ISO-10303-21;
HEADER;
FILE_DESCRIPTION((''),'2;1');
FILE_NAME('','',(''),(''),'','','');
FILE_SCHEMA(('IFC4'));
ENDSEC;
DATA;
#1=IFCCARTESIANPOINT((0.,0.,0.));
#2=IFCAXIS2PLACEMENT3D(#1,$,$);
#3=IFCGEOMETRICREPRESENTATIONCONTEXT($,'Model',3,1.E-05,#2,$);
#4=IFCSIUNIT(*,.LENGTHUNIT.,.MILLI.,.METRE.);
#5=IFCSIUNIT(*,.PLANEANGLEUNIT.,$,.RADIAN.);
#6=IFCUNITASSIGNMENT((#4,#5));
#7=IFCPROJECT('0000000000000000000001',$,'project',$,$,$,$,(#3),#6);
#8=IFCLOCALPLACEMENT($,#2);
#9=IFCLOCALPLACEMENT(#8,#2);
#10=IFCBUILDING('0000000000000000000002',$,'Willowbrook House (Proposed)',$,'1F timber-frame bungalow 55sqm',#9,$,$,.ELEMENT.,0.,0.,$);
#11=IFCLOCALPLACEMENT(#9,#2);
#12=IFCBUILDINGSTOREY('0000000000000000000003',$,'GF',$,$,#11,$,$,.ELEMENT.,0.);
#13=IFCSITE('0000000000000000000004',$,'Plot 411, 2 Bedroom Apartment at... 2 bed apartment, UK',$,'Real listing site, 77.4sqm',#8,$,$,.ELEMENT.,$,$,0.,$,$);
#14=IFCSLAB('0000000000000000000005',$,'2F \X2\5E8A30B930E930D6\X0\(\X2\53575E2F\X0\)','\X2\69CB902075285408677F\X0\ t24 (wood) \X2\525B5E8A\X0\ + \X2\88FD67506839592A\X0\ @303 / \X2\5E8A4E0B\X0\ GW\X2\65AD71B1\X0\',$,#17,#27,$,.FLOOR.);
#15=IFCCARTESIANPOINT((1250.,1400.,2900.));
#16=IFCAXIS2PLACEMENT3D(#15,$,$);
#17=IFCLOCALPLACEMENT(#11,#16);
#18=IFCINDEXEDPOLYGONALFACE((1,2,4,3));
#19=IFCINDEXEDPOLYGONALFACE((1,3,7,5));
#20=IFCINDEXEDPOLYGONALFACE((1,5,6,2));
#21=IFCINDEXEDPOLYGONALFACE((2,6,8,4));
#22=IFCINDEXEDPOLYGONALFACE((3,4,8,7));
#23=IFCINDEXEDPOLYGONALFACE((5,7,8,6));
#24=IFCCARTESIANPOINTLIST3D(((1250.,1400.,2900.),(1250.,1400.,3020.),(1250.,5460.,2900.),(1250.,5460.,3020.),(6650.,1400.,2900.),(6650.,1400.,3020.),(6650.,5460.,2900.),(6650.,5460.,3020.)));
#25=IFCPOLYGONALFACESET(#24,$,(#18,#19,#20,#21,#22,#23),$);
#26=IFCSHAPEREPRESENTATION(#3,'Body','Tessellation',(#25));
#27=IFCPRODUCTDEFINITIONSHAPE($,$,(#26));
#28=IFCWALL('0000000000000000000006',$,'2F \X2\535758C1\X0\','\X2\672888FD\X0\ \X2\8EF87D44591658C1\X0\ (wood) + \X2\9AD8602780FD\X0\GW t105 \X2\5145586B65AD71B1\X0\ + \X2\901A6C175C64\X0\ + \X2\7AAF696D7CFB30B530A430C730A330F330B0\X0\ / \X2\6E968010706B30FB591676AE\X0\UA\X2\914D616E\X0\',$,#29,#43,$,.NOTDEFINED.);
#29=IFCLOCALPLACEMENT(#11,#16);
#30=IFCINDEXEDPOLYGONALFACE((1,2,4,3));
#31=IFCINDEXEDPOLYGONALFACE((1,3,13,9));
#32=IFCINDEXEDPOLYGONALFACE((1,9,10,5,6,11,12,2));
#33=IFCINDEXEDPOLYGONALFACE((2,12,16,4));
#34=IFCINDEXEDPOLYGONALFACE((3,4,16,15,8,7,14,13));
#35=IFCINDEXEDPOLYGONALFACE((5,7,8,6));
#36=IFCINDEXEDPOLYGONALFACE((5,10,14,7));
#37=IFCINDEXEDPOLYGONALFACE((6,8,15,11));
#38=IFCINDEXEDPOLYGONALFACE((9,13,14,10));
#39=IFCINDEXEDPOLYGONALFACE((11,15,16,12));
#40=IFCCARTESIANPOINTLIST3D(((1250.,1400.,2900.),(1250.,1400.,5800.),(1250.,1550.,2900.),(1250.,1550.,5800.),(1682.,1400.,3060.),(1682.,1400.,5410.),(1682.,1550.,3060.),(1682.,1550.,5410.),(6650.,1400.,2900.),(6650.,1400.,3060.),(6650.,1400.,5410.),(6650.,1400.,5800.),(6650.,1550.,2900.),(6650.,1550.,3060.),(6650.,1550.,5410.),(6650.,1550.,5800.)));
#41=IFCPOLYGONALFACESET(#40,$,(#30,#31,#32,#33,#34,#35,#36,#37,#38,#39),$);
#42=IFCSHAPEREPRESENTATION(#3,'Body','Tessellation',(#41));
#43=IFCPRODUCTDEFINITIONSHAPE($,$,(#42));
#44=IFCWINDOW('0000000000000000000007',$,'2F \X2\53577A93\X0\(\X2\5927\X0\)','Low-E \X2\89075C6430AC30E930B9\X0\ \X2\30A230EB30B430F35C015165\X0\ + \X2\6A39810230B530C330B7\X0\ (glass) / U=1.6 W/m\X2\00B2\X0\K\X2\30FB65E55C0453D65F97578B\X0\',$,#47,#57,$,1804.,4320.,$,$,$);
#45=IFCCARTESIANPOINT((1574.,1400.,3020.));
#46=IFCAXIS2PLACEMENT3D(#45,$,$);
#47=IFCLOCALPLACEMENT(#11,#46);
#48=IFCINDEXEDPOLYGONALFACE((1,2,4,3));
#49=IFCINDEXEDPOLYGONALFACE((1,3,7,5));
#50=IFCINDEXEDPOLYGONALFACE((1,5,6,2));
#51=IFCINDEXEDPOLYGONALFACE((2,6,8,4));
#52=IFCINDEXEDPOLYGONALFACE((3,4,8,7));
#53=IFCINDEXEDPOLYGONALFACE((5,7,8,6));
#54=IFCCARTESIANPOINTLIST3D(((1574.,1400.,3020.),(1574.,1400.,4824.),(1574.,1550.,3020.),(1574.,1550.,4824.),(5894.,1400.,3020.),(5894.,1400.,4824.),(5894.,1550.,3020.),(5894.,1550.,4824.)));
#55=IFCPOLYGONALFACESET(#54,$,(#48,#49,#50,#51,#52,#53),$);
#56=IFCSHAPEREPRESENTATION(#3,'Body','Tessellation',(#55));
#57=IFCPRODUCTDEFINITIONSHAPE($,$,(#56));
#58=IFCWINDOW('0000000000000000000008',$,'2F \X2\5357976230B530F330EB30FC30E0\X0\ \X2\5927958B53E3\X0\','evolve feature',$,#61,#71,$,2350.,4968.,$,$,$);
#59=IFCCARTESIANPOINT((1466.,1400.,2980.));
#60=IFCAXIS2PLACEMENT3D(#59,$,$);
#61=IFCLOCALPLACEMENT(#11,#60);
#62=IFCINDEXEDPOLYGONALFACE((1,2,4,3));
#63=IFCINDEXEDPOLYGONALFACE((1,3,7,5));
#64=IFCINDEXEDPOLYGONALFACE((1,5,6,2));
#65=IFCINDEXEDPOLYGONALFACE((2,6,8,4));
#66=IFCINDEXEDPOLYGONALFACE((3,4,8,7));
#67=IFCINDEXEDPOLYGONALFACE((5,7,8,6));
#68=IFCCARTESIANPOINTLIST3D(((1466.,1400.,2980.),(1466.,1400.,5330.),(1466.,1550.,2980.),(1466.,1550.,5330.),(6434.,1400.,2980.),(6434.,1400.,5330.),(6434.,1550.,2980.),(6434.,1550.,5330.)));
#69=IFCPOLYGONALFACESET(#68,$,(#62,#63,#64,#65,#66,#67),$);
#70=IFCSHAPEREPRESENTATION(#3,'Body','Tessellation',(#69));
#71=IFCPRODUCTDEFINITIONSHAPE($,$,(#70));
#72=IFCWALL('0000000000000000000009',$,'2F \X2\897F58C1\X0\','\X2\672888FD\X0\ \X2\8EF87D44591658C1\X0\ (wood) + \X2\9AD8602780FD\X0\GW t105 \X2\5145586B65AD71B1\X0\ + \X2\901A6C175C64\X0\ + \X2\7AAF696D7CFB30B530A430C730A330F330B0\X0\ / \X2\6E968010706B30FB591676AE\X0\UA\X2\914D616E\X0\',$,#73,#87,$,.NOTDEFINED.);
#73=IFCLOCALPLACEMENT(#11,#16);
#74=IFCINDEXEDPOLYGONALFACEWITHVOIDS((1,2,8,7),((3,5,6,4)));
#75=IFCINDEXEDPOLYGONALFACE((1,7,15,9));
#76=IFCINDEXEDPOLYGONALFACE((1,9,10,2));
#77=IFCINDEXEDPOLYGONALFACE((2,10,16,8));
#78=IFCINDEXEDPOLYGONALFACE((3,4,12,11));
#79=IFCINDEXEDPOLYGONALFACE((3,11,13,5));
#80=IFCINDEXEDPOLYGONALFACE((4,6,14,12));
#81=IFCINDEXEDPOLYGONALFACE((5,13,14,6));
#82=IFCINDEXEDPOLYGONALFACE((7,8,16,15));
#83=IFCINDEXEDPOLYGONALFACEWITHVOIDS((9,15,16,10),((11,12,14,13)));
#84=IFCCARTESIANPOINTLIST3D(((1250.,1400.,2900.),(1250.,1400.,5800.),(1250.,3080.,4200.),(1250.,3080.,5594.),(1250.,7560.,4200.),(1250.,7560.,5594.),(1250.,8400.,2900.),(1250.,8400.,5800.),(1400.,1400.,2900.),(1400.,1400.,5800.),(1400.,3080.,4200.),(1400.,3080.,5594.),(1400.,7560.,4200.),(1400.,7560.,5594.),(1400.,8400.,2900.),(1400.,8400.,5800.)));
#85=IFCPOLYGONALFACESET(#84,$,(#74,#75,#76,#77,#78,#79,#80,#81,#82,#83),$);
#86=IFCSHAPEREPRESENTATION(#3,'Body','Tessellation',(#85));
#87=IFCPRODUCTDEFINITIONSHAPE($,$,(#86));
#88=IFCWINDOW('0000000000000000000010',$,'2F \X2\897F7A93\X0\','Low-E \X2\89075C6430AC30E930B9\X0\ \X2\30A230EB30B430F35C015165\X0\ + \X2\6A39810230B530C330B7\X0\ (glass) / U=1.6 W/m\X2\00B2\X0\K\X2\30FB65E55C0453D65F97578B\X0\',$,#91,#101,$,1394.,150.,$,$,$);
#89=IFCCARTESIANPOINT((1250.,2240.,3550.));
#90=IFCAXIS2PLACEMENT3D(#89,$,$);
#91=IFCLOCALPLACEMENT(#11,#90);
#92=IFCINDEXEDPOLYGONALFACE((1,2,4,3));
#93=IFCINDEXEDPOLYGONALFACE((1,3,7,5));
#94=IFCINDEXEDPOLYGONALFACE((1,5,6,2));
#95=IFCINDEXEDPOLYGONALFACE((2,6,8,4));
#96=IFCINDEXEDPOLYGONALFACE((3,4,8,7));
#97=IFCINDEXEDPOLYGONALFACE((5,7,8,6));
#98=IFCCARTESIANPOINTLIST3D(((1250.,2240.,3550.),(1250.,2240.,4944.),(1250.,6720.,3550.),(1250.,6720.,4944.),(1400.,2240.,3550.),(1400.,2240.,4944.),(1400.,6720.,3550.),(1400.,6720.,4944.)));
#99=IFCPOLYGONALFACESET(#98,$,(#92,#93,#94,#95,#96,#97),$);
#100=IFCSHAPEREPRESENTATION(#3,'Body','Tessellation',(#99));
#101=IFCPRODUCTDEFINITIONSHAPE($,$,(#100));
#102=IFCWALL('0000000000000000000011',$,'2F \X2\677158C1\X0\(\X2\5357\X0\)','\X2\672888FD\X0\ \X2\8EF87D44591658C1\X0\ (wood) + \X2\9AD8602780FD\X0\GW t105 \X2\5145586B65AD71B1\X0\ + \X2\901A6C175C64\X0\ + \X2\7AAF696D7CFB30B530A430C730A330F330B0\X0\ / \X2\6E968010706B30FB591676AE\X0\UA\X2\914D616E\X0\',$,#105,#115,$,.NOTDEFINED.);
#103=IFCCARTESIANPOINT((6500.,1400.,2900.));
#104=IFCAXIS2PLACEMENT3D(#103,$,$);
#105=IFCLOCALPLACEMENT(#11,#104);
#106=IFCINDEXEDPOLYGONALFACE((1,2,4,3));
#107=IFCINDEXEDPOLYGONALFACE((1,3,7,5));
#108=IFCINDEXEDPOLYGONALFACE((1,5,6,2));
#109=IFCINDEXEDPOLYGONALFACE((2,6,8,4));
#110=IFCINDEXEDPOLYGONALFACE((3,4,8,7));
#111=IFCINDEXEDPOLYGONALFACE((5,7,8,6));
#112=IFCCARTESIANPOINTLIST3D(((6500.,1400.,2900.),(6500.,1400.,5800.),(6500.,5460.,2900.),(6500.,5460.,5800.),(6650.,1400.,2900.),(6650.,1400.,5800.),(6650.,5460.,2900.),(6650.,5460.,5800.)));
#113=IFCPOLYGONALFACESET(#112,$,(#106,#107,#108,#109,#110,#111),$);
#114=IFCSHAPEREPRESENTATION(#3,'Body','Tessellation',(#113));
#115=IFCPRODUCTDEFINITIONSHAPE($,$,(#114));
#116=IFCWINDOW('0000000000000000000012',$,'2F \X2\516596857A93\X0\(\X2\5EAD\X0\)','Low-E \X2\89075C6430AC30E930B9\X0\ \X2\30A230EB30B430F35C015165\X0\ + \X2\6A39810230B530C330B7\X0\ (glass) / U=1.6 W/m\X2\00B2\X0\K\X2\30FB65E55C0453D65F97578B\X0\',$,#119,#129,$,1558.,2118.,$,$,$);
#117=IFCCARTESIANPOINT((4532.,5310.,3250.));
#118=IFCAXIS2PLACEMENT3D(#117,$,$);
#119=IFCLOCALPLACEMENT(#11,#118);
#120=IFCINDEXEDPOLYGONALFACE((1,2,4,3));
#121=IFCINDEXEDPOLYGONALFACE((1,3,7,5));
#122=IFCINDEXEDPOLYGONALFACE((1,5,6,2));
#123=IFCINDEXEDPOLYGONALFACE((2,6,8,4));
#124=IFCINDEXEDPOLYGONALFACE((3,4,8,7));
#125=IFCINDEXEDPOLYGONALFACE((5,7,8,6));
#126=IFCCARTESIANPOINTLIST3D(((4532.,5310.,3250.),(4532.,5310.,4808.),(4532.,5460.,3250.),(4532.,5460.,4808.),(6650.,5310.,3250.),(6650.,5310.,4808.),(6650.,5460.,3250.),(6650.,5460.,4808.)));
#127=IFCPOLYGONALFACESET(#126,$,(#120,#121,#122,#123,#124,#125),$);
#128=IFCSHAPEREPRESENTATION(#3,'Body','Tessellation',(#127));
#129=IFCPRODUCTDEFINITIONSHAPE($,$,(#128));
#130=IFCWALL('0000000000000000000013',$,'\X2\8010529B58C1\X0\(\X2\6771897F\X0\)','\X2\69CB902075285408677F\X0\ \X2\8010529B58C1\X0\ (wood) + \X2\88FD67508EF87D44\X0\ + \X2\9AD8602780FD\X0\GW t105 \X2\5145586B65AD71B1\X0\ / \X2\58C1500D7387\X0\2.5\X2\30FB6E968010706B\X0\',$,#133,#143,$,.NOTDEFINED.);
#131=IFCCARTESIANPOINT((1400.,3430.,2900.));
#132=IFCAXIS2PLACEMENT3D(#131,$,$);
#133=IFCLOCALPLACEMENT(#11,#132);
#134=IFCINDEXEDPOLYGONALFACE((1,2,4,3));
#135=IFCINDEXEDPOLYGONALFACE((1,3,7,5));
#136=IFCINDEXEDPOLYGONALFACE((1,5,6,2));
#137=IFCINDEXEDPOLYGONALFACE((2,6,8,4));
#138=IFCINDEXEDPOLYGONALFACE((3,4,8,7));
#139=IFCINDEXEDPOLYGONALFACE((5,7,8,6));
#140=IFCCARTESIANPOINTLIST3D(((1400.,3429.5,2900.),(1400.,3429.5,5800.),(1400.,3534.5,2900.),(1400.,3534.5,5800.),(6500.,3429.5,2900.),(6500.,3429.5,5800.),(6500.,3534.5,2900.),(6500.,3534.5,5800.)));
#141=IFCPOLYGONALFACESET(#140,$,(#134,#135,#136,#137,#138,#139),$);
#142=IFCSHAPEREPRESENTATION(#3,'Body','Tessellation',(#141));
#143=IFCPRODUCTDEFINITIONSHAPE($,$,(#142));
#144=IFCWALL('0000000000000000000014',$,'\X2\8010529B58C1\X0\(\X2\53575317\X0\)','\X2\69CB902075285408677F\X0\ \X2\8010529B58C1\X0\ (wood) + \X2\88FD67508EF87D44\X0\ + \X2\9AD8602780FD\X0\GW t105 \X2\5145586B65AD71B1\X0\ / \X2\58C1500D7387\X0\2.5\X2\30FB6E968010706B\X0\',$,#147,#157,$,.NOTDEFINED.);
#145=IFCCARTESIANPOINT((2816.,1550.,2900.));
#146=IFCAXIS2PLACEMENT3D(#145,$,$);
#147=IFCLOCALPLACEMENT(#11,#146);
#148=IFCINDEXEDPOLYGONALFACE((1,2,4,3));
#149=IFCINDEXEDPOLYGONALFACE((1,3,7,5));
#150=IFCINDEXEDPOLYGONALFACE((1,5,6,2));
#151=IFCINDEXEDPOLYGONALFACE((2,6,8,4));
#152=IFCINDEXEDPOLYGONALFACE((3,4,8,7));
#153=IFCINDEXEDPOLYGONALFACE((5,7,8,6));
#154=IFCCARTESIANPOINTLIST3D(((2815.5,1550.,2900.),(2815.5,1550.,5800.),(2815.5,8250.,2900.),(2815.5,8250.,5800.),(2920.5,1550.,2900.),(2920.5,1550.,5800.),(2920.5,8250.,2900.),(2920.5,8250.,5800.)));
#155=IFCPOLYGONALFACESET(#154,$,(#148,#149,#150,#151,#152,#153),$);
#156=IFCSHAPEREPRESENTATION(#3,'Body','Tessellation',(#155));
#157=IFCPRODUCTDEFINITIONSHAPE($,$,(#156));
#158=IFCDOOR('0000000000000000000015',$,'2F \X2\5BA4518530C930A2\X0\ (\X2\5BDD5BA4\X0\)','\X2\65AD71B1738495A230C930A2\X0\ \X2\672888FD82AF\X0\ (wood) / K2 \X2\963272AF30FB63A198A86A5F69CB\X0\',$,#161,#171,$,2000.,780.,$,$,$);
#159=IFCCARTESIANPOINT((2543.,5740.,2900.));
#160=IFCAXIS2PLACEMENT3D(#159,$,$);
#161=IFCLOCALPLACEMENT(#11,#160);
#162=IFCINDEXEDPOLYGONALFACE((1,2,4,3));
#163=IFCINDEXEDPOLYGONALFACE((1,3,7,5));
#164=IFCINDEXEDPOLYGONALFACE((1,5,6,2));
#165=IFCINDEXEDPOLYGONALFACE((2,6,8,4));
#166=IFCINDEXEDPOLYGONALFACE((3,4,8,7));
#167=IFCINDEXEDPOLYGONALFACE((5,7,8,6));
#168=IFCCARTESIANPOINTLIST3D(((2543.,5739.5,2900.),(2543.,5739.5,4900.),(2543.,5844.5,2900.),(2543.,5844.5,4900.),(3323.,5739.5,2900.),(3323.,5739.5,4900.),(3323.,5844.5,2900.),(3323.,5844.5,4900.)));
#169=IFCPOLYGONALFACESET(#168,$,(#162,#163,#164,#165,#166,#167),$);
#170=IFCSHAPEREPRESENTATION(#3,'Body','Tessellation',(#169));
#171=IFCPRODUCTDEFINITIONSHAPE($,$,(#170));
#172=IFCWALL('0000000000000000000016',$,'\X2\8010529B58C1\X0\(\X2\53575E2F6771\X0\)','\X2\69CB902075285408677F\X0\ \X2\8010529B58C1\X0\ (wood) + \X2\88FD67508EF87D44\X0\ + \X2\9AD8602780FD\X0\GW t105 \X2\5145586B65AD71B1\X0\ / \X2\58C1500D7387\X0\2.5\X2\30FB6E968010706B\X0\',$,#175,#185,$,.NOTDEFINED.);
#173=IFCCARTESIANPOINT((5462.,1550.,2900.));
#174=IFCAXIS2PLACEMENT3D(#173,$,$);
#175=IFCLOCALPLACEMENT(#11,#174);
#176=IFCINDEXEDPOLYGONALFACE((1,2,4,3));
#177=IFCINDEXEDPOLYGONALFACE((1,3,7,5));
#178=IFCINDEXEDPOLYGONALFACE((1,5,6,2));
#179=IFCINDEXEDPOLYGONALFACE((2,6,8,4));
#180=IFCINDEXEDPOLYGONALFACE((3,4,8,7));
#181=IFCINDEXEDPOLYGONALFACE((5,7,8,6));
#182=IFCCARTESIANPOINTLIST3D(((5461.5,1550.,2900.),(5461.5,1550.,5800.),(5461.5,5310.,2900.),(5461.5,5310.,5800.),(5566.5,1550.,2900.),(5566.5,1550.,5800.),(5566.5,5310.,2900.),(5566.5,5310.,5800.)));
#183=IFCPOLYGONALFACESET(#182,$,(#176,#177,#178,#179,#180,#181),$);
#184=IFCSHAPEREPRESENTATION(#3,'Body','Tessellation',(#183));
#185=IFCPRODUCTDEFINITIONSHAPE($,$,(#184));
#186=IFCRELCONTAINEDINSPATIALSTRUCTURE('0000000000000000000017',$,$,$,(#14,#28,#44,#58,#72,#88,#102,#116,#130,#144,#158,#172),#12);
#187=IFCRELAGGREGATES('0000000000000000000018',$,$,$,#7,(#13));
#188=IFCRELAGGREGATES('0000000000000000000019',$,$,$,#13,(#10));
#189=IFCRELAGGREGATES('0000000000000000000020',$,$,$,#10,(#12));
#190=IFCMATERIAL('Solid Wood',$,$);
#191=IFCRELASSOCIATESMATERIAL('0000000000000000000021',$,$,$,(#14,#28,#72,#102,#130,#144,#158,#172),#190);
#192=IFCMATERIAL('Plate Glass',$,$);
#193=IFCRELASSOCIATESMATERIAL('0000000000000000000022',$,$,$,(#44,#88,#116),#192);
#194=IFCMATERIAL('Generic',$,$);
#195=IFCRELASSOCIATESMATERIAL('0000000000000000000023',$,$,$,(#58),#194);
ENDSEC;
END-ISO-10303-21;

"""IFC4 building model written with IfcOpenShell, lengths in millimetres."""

from ifc_helpers import new_model, si_unit, frame, frame_2d, origin, place, context, project, spatial, rectangle, extrude, material, element, fill, save


model = new_model("IFC4")

# Units and contexts
model_context = context("Model", 3, precision=1e-05, world=origin())
ifc_project = project(units=[si_unit("LENGTHUNIT", "METRE", prefix="MILLI"), si_unit("PLANEANGLEUNIT", "RADIAN")], contexts=[model_context])

# Site, building, storey
site_placement = place(None, origin())
site = spatial("IfcSite", under=ifc_project, at=site_placement, Name="Plot 411, 2 Bedroom Apartment at... 2 bed apartment, UK", ObjectType="Real listing site, 77.4sqm", CompositionType="ELEMENT", RefElevation=0.0)
building_placement = place(site_placement, origin())
building = spatial("IfcBuilding", under=site, at=building_placement, Name="Willowbrook House (Proposed)", ObjectType="1F timber-frame bungalow 55sqm", CompositionType="ELEMENT", ElevationOfRefHeight=0.0, ElevationOfTerrain=0.0)
storey_placement = place(building_placement, origin())
storey = spatial("IfcBuildingStorey", under=building, at=storey_placement, Name="GF", CompositionType="ELEMENT", Elevation=0.0)

# Slab
ifc_material_1 = material(Name="Solid Wood")
slab_placement = place(storey_placement, frame((1250.0, 1400.0, 2900.0)))
element("IfcSlab", 1, at=slab_placement, inside=storey, material=ifc_material_1, Name="2F 床スラブ(南帯)", Description="構造用合板 t24 (wood) 剛床 + 製材根太 @303 / 床下 GW断熱", PredefinedType="FLOOR", context=model_context, shape_type="SweptSolid", body=[
    extrude(rectangle(XDim=5400.0, YDim=4060.0, at=frame_2d((2700.0, 2030.0))), frame((1250.0, 1400.0, 2900.0)), (0.0, 0.0, 1.0), 120.0),
])

# Wall, openings, windows
wall_1_placement = place(storey_placement, frame((1250.0, 1400.0, 2900.0)))
wall_1 = element("IfcWall", 2, at=wall_1_placement, inside=storey, material=ifc_material_1, Name="2F 南壁", Description="木製 軸組外壁 (wood) + 高性能GW t105 充填断熱 + 通気層 + 窯業系サイディング / 準耐火・外皮UA配慮", PredefinedType="NOTDEFINED", context=model_context, shape_type="SweptSolid", body=[
    extrude(rectangle(XDim=5400.0, YDim=150.0, at=frame_2d((2700.0, 75.0))), frame((1250.0, 1400.0, 2900.0)), (0.0, 0.0, 1.0), 2900.0),
])
opening_1_placement = place(storey_placement, frame((1574.0, 1400.0, 3020.0)))
opening_1 = element("IfcOpeningElement", 3, at=opening_1_placement, cuts=wall_1, PredefinedType="NOTDEFINED", context=model_context, shape_type="SweptSolid", body=[
    extrude(rectangle(XDim=4320.0, YDim=150.0, at=frame_2d((2160.0, 75.0))), frame((1574.0, 1400.0, 3020.0)), (0.0, 0.0, 1.0), 1804.0),
])
opening_2_placement = place(storey_placement, frame((1466.0, 1400.0, 2980.0)))
opening_2 = element("IfcOpeningElement", 4, at=opening_2_placement, cuts=wall_1, PredefinedType="NOTDEFINED", context=model_context, shape_type="SweptSolid", body=[
    extrude(rectangle(XDim=4968.0, YDim=150.0, at=frame_2d((2484.0, 75.0))), frame((1466.0, 1400.0, 2980.0)), (0.0, 0.0, 1.0), 2350.0),
])
ifc_material_2 = material(Name="Plate Glass")
window_1_placement = place(storey_placement, frame((1574.0, 1400.0, 3020.0)))
window_1 = element("IfcWindow", 5, at=window_1_placement, inside=storey, material=ifc_material_2, Name="2F 南窓(大)", Description="Low-E 複層ガラス アルゴン封入 + 樹脂サッシ (glass) / U=1.6 W/m²K・日射取得型", OverallHeight=1804.0, OverallWidth=4320.0, context=model_context, shape_type="SweptSolid", body=[
    extrude(rectangle(XDim=4320.0, YDim=150.0, at=frame_2d((2160.0, 75.0))), frame((1574.0, 1400.0, 3020.0)), (0.0, 0.0, 1.0), 1804.0),
])
fill(opening_1, window_1)
ifc_material_3 = material(Name="Generic")
window_2_placement = place(storey_placement, frame((1466.0, 1400.0, 2980.0)))
window_2 = element("IfcWindow", 6, at=window_2_placement, inside=storey, material=ifc_material_3, Name="2F 南面サンルーム 大開口", Description="evolve feature", OverallHeight=2350.0, OverallWidth=4968.0, context=model_context, shape_type="SweptSolid", body=[
    extrude(rectangle(XDim=4968.0, YDim=150.0, at=frame_2d((2484.0, 75.0))), frame((1466.0, 1400.0, 2980.0)), (0.0, 0.0, 1.0), 2350.0),
])
fill(opening_2, window_2)

# Walls, openings, windows
wall_2_placement = place(storey_placement, frame((1250.0, 1400.0, 2900.0)))
wall_2 = element("IfcWall", 7, at=wall_2_placement, inside=storey, material=ifc_material_1, Name="2F 西壁", Description="木製 軸組外壁 (wood) + 高性能GW t105 充填断熱 + 通気層 + 窯業系サイディング / 準耐火・外皮UA配慮", PredefinedType="NOTDEFINED", context=model_context, shape_type="SweptSolid", body=[
    extrude(rectangle(XDim=150.0, YDim=7000.0, at=frame_2d((75.0, 3500.0))), frame((1250.0, 1400.0, 2900.0)), (0.0, 0.0, 1.0), 2900.0),
])
opening_3_placement = place(storey_placement, frame((1250.0, 2240.0, 3550.0)))
opening_3 = element("IfcOpeningElement", 8, at=opening_3_placement, cuts=wall_2, PredefinedType="NOTDEFINED", context=model_context, shape_type="SweptSolid", body=[
    extrude(rectangle(XDim=150.0, YDim=4480.0, at=frame_2d((75.0, 2240.0))), frame((1250.0, 2240.0, 3550.0)), (0.0, 0.0, 1.0), 1394.0),
])
window_3_placement = place(storey_placement, frame((1250.0, 2240.0, 3550.0)))
window_3 = element("IfcWindow", 9, at=window_3_placement, inside=storey, material=ifc_material_2, Name="2F 西窓", Description="Low-E 複層ガラス アルゴン封入 + 樹脂サッシ (glass) / U=1.6 W/m²K・日射取得型", OverallHeight=1394.0, OverallWidth=150.0, context=model_context, shape_type="SweptSolid", body=[
    extrude(rectangle(XDim=150.0, YDim=4480.0, at=frame_2d((75.0, 2240.0))), frame((1250.0, 2240.0, 3550.0)), (0.0, 0.0, 1.0), 1394.0),
])
fill(opening_3, window_3)
wall_3_placement = place(storey_placement, frame((6500.0, 1400.0, 2900.0)))
wall_3 = element("IfcWall", 10, at=wall_3_placement, inside=storey, material=ifc_material_1, Name="2F 東壁(南)", Description="木製 軸組外壁 (wood) + 高性能GW t105 充填断熱 + 通気層 + 窯業系サイディング / 準耐火・外皮UA配慮", PredefinedType="NOTDEFINED", context=model_context, shape_type="SweptSolid", body=[
    extrude(rectangle(XDim=150.0, YDim=4060.0, at=frame_2d((75.0, 2030.0))), frame((6500.0, 1400.0, 2900.0)), (0.0, 0.0, 1.0), 2900.0),
])
opening_4_placement = place(storey_placement, frame((4532.0, 5310.0, 3250.0)))
opening_4 = element("IfcOpeningElement", 11, at=opening_4_placement, cuts=wall_3, PredefinedType="NOTDEFINED", context=model_context, shape_type="SweptSolid", body=[
    extrude(rectangle(XDim=2118.0, YDim=150.0, at=frame_2d((1059.0, 75.0))), frame((4532.0, 5310.0, 3250.0)), (0.0, 0.0, 1.0), 1558.0),
])
window_4_placement = place(storey_placement, frame((4532.0, 5310.0, 3250.0)))
window_4 = element("IfcWindow", 12, at=window_4_placement, inside=storey, material=ifc_material_2, Name="2F 入隅窓(庭)", Description="Low-E 複層ガラス アルゴン封入 + 樹脂サッシ (glass) / U=1.6 W/m²K・日射取得型", OverallHeight=1558.0, OverallWidth=2118.0, context=model_context, shape_type="SweptSolid", body=[
    extrude(rectangle(XDim=2118.0, YDim=150.0, at=frame_2d((1059.0, 75.0))), frame((4532.0, 5310.0, 3250.0)), (0.0, 0.0, 1.0), 1558.0),
])
fill(opening_4, window_4)

# Wall
wall_4_placement = place(storey_placement, frame((1400.0, 3430.0, 2900.0)))
element("IfcWall", 13, at=wall_4_placement, inside=storey, material=ifc_material_1, Name="耐力壁(東西)", Description="構造用合板 耐力壁 (wood) + 製材軸組 + 高性能GW t105 充填断熱 / 壁倍率2.5・準耐火", PredefinedType="NOTDEFINED", context=model_context, shape_type="SweptSolid", body=[
    extrude(rectangle(XDim=5100.0, YDim=105.0, at=frame_2d((2550.0, 52.0))), frame((1400.0, 3430.0, 2900.0)), (0.0, 0.0, 1.0), 2900.0),
])

# Wall, opening, door
wall_5_placement = place(storey_placement, frame((2816.0, 1550.0, 2900.0)))
wall_5 = element("IfcWall", 14, at=wall_5_placement, inside=storey, material=ifc_material_1, Name="耐力壁(南北)", Description="構造用合板 耐力壁 (wood) + 製材軸組 + 高性能GW t105 充填断熱 / 壁倍率2.5・準耐火", PredefinedType="NOTDEFINED", context=model_context, shape_type="SweptSolid", body=[
    extrude(rectangle(XDim=105.0, YDim=6700.0, at=frame_2d((52.0, 3350.0))), frame((2816.0, 1550.0, 2900.0)), (0.0, 0.0, 1.0), 2900.0),
])
opening_5_placement = place(storey_placement, frame((2543.0, 5740.0, 2900.0)))
opening_5 = element("IfcOpeningElement", 15, at=opening_5_placement, cuts=wall_5, PredefinedType="NOTDEFINED", context=model_context, shape_type="SweptSolid", body=[
    extrude(rectangle(XDim=780.0, YDim=105.0, at=frame_2d((390.0, 52.0))), frame((2543.0, 5740.0, 2900.0)), (0.0, 0.0, 1.0), 2000.0),
])
door_placement = place(storey_placement, frame((2543.0, 5740.0, 2900.0)))
door = element("IfcDoor", 16, at=door_placement, inside=storey, material=ifc_material_1, Name="2F 室内ドア (寝室)", Description="断熱玄関ドア 木製芯 (wood) / K2 防犯・採風機構", OverallHeight=2000.0, OverallWidth=780.0, context=model_context, shape_type="SweptSolid", body=[
    extrude(rectangle(XDim=780.0, YDim=105.0, at=frame_2d((390.0, 52.0))), frame((2543.0, 5740.0, 2900.0)), (0.0, 0.0, 1.0), 2000.0),
])
fill(opening_5, door)

# Wall
wall_6_placement = place(storey_placement, frame((5462.0, 1550.0, 2900.0)))
element("IfcWall", 17, at=wall_6_placement, inside=storey, material=ifc_material_1, Name="耐力壁(南帯東)", Description="構造用合板 耐力壁 (wood) + 製材軸組 + 高性能GW t105 充填断熱 / 壁倍率2.5・準耐火", PredefinedType="NOTDEFINED", context=model_context, shape_type="SweptSolid", body=[
    extrude(rectangle(XDim=105.0, YDim=3760.0, at=frame_2d((52.0, 1880.0))), frame((5462.0, 1550.0, 2900.0)), (0.0, 0.0, 1.0), 2900.0),
])

save(model, "model.ifc")
